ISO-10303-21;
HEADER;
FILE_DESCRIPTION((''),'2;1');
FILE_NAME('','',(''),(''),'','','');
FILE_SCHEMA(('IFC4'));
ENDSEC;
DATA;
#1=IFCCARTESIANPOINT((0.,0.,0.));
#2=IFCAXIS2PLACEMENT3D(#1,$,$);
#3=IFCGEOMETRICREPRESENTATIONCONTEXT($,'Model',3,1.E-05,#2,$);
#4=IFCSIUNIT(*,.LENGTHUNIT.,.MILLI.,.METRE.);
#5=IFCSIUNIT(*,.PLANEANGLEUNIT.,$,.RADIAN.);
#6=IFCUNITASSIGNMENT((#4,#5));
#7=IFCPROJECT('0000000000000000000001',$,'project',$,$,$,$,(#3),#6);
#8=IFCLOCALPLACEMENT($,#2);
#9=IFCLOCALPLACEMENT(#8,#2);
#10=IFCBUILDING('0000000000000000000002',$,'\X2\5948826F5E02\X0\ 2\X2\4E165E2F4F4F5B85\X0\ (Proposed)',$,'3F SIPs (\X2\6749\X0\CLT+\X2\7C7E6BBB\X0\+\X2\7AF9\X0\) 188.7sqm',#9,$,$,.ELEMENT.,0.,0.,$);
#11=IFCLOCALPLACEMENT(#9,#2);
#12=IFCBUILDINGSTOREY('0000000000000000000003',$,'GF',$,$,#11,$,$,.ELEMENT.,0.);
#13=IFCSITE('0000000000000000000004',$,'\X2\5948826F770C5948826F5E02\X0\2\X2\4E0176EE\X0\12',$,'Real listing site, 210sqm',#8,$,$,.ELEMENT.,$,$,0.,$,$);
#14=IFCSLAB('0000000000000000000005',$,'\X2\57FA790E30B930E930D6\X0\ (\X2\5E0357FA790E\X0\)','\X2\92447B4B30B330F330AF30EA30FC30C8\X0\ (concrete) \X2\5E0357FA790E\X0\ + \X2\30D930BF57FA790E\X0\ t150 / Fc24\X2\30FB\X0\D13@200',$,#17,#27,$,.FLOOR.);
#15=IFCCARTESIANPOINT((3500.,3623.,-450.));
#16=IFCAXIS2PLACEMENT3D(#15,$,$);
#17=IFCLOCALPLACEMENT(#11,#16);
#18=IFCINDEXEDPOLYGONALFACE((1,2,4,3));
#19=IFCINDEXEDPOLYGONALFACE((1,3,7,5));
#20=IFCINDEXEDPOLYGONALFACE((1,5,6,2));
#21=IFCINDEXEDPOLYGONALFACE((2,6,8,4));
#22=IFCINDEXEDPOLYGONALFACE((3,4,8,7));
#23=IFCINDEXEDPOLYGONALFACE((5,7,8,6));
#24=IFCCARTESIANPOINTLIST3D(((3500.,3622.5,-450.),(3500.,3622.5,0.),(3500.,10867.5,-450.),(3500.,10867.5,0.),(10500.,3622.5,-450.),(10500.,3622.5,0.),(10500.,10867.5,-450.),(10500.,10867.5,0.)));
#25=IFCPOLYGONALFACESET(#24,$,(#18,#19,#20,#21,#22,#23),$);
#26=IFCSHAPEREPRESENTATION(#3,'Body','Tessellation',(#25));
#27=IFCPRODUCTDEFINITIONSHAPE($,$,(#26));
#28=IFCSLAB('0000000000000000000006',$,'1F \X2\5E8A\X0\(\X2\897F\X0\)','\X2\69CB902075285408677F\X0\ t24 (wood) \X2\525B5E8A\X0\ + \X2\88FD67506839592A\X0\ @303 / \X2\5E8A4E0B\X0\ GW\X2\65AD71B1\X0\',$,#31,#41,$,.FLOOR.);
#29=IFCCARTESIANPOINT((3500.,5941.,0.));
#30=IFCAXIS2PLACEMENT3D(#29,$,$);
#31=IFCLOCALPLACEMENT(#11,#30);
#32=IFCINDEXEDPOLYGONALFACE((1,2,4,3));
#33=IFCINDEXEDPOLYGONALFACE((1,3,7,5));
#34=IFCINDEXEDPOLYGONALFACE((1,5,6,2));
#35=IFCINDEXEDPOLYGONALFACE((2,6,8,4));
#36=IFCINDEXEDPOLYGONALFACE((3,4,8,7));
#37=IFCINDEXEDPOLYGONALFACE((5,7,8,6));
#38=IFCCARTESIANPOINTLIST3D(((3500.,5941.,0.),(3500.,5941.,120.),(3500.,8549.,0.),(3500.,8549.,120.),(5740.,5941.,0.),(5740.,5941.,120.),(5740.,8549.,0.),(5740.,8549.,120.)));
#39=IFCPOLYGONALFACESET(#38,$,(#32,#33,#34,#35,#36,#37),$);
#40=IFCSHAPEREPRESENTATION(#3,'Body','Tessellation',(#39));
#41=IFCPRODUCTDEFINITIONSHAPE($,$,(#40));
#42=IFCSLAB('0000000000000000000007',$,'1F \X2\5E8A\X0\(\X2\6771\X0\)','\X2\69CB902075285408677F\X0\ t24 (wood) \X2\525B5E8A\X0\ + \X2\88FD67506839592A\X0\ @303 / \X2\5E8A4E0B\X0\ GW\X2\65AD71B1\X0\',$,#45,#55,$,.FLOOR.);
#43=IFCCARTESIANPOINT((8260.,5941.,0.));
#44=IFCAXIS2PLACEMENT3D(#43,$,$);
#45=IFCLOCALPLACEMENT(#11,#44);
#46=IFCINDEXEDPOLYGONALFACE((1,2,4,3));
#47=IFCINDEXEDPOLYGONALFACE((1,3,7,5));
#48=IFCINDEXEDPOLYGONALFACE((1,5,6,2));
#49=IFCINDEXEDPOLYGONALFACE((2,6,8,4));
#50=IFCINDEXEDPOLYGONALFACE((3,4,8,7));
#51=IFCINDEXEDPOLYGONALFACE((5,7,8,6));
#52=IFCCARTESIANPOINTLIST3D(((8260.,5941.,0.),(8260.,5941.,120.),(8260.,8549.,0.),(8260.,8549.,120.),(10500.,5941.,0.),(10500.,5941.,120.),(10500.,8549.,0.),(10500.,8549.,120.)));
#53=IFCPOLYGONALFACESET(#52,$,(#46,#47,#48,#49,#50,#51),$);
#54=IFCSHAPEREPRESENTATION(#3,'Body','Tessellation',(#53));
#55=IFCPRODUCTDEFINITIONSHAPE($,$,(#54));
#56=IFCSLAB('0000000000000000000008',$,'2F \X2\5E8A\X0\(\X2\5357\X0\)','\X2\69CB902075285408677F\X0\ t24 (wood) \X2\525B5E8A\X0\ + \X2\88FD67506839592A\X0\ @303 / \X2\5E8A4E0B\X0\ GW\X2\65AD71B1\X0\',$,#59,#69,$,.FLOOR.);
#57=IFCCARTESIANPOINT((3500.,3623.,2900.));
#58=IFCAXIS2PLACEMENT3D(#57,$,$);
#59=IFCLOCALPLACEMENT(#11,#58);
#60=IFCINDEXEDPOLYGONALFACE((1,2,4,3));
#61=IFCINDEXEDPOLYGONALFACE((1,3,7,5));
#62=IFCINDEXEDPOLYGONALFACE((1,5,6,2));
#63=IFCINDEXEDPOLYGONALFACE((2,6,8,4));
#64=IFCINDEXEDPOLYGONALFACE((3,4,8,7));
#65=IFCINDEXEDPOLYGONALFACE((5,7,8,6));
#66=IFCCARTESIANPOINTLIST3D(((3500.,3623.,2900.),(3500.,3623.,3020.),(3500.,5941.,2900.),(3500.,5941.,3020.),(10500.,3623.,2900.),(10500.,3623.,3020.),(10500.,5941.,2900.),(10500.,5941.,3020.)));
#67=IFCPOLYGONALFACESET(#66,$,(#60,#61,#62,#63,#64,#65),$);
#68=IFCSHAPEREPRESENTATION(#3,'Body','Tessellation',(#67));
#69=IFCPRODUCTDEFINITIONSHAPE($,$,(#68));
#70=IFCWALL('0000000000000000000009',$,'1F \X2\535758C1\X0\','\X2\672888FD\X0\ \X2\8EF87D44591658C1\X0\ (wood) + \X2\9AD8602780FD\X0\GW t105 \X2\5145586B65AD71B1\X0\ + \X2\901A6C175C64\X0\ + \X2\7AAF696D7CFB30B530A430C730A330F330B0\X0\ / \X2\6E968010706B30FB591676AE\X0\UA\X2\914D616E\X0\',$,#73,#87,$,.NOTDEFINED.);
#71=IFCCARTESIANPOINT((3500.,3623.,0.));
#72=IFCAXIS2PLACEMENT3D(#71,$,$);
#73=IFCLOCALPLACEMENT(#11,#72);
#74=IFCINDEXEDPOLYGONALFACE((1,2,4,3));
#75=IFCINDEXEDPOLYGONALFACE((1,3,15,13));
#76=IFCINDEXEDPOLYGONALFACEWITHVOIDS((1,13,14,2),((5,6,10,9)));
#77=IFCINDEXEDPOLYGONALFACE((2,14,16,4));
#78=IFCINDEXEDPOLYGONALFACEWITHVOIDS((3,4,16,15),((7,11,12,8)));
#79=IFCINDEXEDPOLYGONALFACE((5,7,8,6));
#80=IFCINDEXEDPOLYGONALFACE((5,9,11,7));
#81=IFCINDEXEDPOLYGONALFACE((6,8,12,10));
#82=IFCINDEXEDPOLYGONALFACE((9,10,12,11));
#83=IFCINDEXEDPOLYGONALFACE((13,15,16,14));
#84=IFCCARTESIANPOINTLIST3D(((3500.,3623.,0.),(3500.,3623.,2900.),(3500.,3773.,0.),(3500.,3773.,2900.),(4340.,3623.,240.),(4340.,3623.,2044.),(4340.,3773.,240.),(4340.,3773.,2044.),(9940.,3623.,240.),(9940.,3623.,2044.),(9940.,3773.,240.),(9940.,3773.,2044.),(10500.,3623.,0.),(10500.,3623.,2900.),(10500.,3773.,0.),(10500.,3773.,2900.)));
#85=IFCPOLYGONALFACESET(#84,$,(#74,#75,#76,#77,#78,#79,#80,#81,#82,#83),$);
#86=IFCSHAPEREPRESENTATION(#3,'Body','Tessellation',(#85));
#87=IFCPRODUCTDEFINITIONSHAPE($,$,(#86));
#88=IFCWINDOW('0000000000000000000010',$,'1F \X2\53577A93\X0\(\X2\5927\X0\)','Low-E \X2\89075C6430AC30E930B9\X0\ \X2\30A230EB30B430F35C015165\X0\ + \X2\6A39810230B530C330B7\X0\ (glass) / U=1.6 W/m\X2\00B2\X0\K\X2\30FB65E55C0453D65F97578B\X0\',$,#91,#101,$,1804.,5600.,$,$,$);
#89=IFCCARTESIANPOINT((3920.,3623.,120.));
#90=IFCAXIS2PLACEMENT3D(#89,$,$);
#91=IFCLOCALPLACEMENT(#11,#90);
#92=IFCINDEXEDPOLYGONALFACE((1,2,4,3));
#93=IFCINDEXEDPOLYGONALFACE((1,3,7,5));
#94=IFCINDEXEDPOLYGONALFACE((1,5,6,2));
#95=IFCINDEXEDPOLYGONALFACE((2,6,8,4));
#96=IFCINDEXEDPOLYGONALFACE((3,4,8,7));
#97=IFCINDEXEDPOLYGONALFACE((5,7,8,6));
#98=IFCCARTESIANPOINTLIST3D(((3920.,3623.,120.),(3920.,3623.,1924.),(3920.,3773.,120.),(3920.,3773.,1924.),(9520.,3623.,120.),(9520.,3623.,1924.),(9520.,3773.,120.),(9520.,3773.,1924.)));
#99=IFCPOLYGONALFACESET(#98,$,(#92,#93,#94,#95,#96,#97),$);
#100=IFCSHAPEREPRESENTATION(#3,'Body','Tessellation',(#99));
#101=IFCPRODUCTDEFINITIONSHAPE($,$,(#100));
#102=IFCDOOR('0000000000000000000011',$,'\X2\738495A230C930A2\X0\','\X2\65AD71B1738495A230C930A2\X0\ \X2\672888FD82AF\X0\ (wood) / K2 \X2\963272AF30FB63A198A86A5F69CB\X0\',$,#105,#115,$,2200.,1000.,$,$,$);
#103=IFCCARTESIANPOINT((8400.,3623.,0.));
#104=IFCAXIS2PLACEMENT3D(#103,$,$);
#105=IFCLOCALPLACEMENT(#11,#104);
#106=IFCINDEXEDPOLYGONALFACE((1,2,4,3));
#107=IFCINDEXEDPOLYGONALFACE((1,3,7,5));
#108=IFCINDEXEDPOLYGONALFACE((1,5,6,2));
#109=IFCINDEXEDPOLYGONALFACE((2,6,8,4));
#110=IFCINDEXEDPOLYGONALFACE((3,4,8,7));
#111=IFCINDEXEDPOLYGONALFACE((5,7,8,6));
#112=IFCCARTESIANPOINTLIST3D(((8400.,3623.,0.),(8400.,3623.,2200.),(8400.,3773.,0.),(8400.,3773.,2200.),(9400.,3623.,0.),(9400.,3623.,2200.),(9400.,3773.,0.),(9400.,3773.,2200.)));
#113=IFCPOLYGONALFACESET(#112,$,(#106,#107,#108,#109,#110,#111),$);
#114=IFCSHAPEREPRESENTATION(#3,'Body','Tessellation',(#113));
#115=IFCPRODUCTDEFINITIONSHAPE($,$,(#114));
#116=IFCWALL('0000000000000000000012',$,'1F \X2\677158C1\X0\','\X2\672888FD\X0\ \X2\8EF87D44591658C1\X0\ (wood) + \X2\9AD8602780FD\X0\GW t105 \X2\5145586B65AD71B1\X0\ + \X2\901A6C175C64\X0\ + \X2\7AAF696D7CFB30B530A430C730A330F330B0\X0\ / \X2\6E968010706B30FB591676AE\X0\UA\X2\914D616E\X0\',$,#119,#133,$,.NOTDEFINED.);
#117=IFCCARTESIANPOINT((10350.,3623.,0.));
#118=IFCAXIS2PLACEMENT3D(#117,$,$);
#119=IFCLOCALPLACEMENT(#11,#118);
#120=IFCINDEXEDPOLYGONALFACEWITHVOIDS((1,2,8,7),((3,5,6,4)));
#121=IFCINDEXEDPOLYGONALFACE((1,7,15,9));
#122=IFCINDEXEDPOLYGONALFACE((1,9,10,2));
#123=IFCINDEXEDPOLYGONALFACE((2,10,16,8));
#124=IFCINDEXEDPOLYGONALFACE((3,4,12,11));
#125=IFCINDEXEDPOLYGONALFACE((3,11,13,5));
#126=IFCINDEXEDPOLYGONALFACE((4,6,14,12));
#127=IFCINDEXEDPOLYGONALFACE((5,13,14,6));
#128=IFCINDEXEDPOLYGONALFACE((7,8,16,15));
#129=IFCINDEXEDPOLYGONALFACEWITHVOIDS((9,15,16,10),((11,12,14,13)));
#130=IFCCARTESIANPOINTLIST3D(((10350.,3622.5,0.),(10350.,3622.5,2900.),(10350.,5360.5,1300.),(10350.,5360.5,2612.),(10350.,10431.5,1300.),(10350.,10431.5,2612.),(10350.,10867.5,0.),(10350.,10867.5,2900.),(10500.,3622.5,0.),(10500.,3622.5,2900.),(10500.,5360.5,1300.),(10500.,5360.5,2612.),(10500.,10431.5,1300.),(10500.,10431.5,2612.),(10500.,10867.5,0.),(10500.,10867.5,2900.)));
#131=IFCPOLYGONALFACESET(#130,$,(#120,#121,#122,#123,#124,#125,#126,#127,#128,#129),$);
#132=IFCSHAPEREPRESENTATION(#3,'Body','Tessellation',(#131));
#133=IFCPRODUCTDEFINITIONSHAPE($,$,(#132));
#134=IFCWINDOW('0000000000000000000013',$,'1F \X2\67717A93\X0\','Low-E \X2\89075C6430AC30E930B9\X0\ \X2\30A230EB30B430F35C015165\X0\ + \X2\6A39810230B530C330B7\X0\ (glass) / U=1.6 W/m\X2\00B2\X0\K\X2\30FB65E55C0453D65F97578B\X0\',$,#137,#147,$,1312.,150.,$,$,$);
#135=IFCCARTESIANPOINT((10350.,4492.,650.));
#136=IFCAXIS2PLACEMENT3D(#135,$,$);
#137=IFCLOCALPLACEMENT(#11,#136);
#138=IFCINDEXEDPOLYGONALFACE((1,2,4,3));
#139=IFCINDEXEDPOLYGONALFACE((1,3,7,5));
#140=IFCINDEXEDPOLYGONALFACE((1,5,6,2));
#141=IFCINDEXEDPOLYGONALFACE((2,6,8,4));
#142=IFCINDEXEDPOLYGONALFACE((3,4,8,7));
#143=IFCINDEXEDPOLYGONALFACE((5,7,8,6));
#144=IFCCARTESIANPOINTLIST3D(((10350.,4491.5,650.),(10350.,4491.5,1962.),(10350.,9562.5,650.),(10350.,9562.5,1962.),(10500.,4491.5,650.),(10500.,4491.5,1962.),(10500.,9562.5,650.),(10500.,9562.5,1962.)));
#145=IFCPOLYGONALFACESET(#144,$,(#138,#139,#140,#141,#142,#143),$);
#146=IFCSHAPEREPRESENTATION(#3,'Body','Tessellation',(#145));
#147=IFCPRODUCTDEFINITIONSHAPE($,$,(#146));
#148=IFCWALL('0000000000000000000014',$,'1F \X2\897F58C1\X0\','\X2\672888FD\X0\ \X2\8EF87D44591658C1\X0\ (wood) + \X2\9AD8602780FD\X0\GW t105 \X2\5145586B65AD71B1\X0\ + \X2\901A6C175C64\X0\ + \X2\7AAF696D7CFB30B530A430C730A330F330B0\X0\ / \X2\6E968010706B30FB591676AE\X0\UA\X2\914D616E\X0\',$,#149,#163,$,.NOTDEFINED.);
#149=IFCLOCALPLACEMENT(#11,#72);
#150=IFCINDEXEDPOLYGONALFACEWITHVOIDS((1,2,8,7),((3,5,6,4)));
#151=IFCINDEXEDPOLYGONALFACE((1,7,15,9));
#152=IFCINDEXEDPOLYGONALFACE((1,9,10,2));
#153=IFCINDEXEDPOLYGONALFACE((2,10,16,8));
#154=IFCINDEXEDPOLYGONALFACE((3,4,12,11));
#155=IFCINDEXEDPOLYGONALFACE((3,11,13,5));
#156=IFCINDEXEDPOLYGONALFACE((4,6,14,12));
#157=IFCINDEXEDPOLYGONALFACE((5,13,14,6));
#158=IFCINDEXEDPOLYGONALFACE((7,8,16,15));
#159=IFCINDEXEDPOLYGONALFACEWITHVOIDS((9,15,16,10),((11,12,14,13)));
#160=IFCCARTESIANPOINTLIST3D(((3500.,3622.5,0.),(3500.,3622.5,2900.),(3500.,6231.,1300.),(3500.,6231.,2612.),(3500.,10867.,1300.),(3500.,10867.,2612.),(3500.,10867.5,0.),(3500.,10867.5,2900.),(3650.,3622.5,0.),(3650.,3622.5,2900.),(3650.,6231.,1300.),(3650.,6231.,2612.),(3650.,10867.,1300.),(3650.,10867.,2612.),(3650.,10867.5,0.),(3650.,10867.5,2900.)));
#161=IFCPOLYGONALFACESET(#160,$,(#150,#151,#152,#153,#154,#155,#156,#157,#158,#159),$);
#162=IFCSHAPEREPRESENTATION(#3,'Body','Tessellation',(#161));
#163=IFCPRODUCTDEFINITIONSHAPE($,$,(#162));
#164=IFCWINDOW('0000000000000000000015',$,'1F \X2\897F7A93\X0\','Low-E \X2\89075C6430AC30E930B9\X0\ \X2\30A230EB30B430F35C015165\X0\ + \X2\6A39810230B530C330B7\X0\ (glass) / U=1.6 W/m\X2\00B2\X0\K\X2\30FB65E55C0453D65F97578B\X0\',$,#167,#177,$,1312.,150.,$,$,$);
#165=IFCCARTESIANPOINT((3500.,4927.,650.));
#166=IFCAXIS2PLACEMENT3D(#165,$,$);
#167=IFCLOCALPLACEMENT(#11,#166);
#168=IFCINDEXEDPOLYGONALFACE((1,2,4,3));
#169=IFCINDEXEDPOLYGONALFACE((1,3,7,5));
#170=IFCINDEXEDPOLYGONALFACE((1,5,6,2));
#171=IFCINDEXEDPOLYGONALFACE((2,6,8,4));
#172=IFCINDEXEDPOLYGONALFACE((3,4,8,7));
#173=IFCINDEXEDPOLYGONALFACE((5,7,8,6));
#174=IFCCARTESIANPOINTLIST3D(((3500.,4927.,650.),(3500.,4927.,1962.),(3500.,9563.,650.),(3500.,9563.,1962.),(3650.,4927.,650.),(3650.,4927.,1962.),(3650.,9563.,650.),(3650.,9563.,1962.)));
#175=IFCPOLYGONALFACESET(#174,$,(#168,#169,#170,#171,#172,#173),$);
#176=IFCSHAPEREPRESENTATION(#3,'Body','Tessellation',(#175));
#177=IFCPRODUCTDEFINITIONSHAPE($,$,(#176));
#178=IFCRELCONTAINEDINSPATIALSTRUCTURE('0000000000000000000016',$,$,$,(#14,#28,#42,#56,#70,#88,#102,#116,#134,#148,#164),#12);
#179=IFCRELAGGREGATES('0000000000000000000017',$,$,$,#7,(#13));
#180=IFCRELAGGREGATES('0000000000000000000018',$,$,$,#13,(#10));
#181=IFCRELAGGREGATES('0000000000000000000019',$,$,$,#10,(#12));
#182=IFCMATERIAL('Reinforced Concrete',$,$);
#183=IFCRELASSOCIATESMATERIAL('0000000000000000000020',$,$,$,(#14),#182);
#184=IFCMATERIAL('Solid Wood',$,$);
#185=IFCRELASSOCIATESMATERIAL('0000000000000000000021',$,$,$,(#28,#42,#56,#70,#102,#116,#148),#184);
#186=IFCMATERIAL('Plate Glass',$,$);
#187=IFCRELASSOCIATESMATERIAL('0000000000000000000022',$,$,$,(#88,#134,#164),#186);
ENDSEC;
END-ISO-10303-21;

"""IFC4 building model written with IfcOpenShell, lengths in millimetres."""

from ifc_helpers import new_model, si_unit, frame, frame_2d, origin, place, context, project, spatial, rectangle, extrude, material, element, fill, save


model = new_model("IFC4")

# Units and contexts
model_context = context("Model", 3, precision=1e-05, world=origin())
ifc_project = project(units=[si_unit("LENGTHUNIT", "METRE", prefix="MILLI"), si_unit("PLANEANGLEUNIT", "RADIAN")], contexts=[model_context])

# Site, building, storey
site_placement = place(None, origin())
site = spatial("IfcSite", under=ifc_project, at=site_placement, Name="奈良県奈良市2丁目12", ObjectType="Real listing site, 210sqm", CompositionType="ELEMENT", RefElevation=0.0)
building_placement = place(site_placement, origin())
building = spatial("IfcBuilding", under=site, at=building_placement, Name="奈良市 2世帯住宅 (Proposed)", ObjectType="3F SIPs (杉CLT+籾殻+竹) 188.7sqm", CompositionType="ELEMENT", ElevationOfRefHeight=0.0, ElevationOfTerrain=0.0)
storey_placement = place(building_placement, origin())
storey = spatial("IfcBuildingStorey", under=building, at=storey_placement, Name="GF", CompositionType="ELEMENT", Elevation=0.0)

# Slabs
ifc_material_1 = material(Name="Reinforced Concrete")
slab_1_placement = place(storey_placement, frame((3500.0, 3623.0, -450.0)))
element("IfcSlab", 1, at=slab_1_placement, inside=storey, material=ifc_material_1, Name="基礎スラブ (布基礎)", Description="鉄筋コンクリート (concrete) 布基礎 + ベタ基礎 t150 / Fc24・D13@200", PredefinedType="FLOOR", context=model_context, shape_type="SweptSolid", body=[
    extrude(rectangle(XDim=7000.0, YDim=7245.0, at=frame_2d((3500.0, 3622.0))), frame((3500.0, 3623.0, -450.0)), (0.0, 0.0, 1.0), 450.0),
])
ifc_material_2 = material(Name="Solid Wood")
slab_2_placement = place(storey_placement, frame((3500.0, 5941.0, 0.0)))
element("IfcSlab", 2, at=slab_2_placement, inside=storey, material=ifc_material_2, Name="1F 床(西)", Description="構造用合板 t24 (wood) 剛床 + 製材根太 @303 / 床下 GW断熱", PredefinedType="FLOOR", context=model_context, shape_type="SweptSolid", body=[
    extrude(rectangle(XDim=2240.0, YDim=2608.0, at=frame_2d((1120.0, 1304.0))), frame((3500.0, 5941.0, 0.0)), (0.0, 0.0, 1.0), 120.0),
])
slab_3_placement = place(storey_placement, frame((8260.0, 5941.0, 0.0)))
element("IfcSlab", 3, at=slab_3_placement, inside=storey, material=ifc_material_2, Name="1F 床(東)", Description="構造用合板 t24 (wood) 剛床 + 製材根太 @303 / 床下 GW断熱", PredefinedType="FLOOR", context=model_context, shape_type="SweptSolid", body=[
    extrude(rectangle(XDim=2240.0, YDim=2608.0, at=frame_2d((1120.0, 1304.0))), frame((8260.0, 5941.0, 0.0)), (0.0, 0.0, 1.0), 120.0),
])
slab_4_placement = place(storey_placement, frame((3500.0, 3623.0, 2900.0)))
element("IfcSlab", 4, at=slab_4_placement, inside=storey, material=ifc_material_2, Name="2F 床(南)", Description="構造用合板 t24 (wood) 剛床 + 製材根太 @303 / 床下 GW断熱", PredefinedType="FLOOR", context=model_context, shape_type="SweptSolid", body=[
    extrude(rectangle(XDim=7000.0, YDim=2318.0, at=frame_2d((3500.0, 1159.0))), frame((3500.0, 3623.0, 2900.0)), (0.0, 0.0, 1.0), 120.0),
])

# Wall, openings, window, door
wall_1_placement = place(storey_placement, frame((3500.0, 3623.0, 0.0)))
wall_1 = element("IfcWall", 5, at=wall_1_placement, inside=storey, material=ifc_material_2, Name="1F 南壁", Description="木製 軸組外壁 (wood) + 高性能GW t105 充填断熱 + 通気層 + 窯業系サイディング / 準耐火・外皮UA配慮", PredefinedType="NOTDEFINED", context=model_context, shape_type="SweptSolid", body=[
    extrude(rectangle(XDim=7000.0, YDim=150.0, at=frame_2d((3500.0, 75.0))), frame((3500.0, 3623.0, 0.0)), (0.0, 0.0, 1.0), 2900.0),
])
opening_1_placement = place(storey_placement, frame((3920.0, 3623.0, 120.0)))
opening_1 = element("IfcOpeningElement", 6, at=opening_1_placement, cuts=wall_1, PredefinedType="NOTDEFINED", context=model_context, shape_type="SweptSolid", body=[
    extrude(rectangle(XDim=5600.0, YDim=150.0, at=frame_2d((2800.0, 75.0))), frame((3920.0, 3623.0, 120.0)), (0.0, 0.0, 1.0), 1804.0),
])
opening_2_placement = place(storey_placement, frame((8400.0, 3623.0, 0.0)))
opening_2 = element("IfcOpeningElement", 7, at=opening_2_placement, cuts=wall_1, PredefinedType="NOTDEFINED", context=model_context, shape_type="SweptSolid", body=[
    extrude(rectangle(XDim=1000.0, YDim=150.0, at=frame_2d((500.0, 75.0))), frame((8400.0, 3623.0, 0.0)), (0.0, 0.0, 1.0), 2200.0),
])
ifc_material_3 = material(Name="Plate Glass")
window_1_placement = place(storey_placement, frame((3920.0, 3623.0, 120.0)))
window_1 = element("IfcWindow", 8, at=window_1_placement, inside=storey, material=ifc_material_3, Name="1F 南窓(大)", Description="Low-E 複層ガラス アルゴン封入 + 樹脂サッシ (glass) / U=1.6 W/m²K・日射取得型", OverallHeight=1804.0, OverallWidth=5600.0, context=model_context, shape_type="SweptSolid", body=[
    extrude(rectangle(XDim=5600.0, YDim=150.0, at=frame_2d((2800.0, 75.0))), frame((3920.0, 3623.0, 120.0)), (0.0, 0.0, 1.0), 1804.0),
])
fill(opening_1, window_1)
door_placement = place(storey_placement, frame((8400.0, 3623.0, 0.0)))
door = element("IfcDoor", 9, at=door_placement, inside=storey, material=ifc_material_2, Name="玄関ドア", Description="断熱玄関ドア 木製芯 (wood) / K2 防犯・採風機構", OverallHeight=2200.0, OverallWidth=1000.0, context=model_context, shape_type="SweptSolid", body=[
    extrude(rectangle(XDim=1000.0, YDim=150.0, at=frame_2d((500.0, 75.0))), frame((8400.0, 3623.0, 0.0)), (0.0, 0.0, 1.0), 2200.0),
])
fill(opening_2, door)

# Walls, openings, windows
wall_2_placement = place(storey_placement, frame((10350.0, 3623.0, 0.0)))
wall_2 = element("IfcWall", 10, at=wall_2_placement, inside=storey, material=ifc_material_2, Name="1F 東壁", Description="木製 軸組外壁 (wood) + 高性能GW t105 充填断熱 + 通気層 + 窯業系サイディング / 準耐火・外皮UA配慮", PredefinedType="NOTDEFINED", context=model_context, shape_type="SweptSolid", body=[
    extrude(rectangle(XDim=150.0, YDim=7245.0, at=frame_2d((75.0, 3622.0))), frame((10350.0, 3623.0, 0.0)), (0.0, 0.0, 1.0), 2900.0),
])
opening_3_placement = place(storey_placement, frame((10350.0, 4492.0, 650.0)))
opening_3 = element("IfcOpeningElement", 11, at=opening_3_placement, cuts=wall_2, PredefinedType="NOTDEFINED", context=model_context, shape_type="SweptSolid", body=[
    extrude(rectangle(XDim=150.0, YDim=5071.0, at=frame_2d((75.0, 2535.0))), frame((10350.0, 4492.0, 650.0)), (0.0, 0.0, 1.0), 1312.0),
])
window_2_placement = place(storey_placement, frame((10350.0, 4492.0, 650.0)))
window_2 = element("IfcWindow", 12, at=window_2_placement, inside=storey, material=ifc_material_3, Name="1F 東窓", Description="Low-E 複層ガラス アルゴン封入 + 樹脂サッシ (glass) / U=1.6 W/m²K・日射取得型", OverallHeight=1312.0, OverallWidth=150.0, context=model_context, shape_type="SweptSolid", body=[
    extrude(rectangle(XDim=150.0, YDim=5071.0, at=frame_2d((75.0, 2535.0))), frame((10350.0, 4492.0, 650.0)), (0.0, 0.0, 1.0), 1312.0),
])
fill(opening_3, window_2)
wall_3_placement = place(storey_placement, frame((3500.0, 3623.0, 0.0)))
wall_3 = element("IfcWall", 13, at=wall_3_placement, inside=storey, material=ifc_material_2, Name="1F 西壁", Description="木製 軸組外壁 (wood) + 高性能GW t105 充填断熱 + 通気層 + 窯業系サイディング / 準耐火・外皮UA配慮", PredefinedType="NOTDEFINED", context=model_context, shape_type="SweptSolid", body=[
    extrude(rectangle(XDim=150.0, YDim=7245.0, at=frame_2d((75.0, 3622.0))), frame((3500.0, 3623.0, 0.0)), (0.0, 0.0, 1.0), 2900.0),
])
opening_4_placement = place(storey_placement, frame((3500.0, 4927.0, 650.0)))
opening_4 = element("IfcOpeningElement", 14, at=opening_4_placement, cuts=wall_3, PredefinedType="NOTDEFINED", context=model_context, shape_type="SweptSolid", body=[
    extrude(rectangle(XDim=150.0, YDim=4636.0, at=frame_2d((75.0, 2318.0))), frame((3500.0, 4927.0, 650.0)), (0.0, 0.0, 1.0), 1312.0),
])
window_3_placement = place(storey_placement, frame((3500.0, 4927.0, 650.0)))
window_3 = element("IfcWindow", 15, at=window_3_placement, inside=storey, material=ifc_material_3, Name="1F 西窓", Description="Low-E 複層ガラス アルゴン封入 + 樹脂サッシ (glass) / U=1.6 W/m²K・日射取得型", OverallHeight=1312.0, OverallWidth=150.0, context=model_context, shape_type="SweptSolid", body=[
    extrude(rectangle(XDim=150.0, YDim=4636.0, at=frame_2d((75.0, 2318.0))), frame((3500.0, 4927.0, 650.0)), (0.0, 0.0, 1.0), 1312.0),
])
fill(opening_4, window_3)

save(model, "model.ifc")
